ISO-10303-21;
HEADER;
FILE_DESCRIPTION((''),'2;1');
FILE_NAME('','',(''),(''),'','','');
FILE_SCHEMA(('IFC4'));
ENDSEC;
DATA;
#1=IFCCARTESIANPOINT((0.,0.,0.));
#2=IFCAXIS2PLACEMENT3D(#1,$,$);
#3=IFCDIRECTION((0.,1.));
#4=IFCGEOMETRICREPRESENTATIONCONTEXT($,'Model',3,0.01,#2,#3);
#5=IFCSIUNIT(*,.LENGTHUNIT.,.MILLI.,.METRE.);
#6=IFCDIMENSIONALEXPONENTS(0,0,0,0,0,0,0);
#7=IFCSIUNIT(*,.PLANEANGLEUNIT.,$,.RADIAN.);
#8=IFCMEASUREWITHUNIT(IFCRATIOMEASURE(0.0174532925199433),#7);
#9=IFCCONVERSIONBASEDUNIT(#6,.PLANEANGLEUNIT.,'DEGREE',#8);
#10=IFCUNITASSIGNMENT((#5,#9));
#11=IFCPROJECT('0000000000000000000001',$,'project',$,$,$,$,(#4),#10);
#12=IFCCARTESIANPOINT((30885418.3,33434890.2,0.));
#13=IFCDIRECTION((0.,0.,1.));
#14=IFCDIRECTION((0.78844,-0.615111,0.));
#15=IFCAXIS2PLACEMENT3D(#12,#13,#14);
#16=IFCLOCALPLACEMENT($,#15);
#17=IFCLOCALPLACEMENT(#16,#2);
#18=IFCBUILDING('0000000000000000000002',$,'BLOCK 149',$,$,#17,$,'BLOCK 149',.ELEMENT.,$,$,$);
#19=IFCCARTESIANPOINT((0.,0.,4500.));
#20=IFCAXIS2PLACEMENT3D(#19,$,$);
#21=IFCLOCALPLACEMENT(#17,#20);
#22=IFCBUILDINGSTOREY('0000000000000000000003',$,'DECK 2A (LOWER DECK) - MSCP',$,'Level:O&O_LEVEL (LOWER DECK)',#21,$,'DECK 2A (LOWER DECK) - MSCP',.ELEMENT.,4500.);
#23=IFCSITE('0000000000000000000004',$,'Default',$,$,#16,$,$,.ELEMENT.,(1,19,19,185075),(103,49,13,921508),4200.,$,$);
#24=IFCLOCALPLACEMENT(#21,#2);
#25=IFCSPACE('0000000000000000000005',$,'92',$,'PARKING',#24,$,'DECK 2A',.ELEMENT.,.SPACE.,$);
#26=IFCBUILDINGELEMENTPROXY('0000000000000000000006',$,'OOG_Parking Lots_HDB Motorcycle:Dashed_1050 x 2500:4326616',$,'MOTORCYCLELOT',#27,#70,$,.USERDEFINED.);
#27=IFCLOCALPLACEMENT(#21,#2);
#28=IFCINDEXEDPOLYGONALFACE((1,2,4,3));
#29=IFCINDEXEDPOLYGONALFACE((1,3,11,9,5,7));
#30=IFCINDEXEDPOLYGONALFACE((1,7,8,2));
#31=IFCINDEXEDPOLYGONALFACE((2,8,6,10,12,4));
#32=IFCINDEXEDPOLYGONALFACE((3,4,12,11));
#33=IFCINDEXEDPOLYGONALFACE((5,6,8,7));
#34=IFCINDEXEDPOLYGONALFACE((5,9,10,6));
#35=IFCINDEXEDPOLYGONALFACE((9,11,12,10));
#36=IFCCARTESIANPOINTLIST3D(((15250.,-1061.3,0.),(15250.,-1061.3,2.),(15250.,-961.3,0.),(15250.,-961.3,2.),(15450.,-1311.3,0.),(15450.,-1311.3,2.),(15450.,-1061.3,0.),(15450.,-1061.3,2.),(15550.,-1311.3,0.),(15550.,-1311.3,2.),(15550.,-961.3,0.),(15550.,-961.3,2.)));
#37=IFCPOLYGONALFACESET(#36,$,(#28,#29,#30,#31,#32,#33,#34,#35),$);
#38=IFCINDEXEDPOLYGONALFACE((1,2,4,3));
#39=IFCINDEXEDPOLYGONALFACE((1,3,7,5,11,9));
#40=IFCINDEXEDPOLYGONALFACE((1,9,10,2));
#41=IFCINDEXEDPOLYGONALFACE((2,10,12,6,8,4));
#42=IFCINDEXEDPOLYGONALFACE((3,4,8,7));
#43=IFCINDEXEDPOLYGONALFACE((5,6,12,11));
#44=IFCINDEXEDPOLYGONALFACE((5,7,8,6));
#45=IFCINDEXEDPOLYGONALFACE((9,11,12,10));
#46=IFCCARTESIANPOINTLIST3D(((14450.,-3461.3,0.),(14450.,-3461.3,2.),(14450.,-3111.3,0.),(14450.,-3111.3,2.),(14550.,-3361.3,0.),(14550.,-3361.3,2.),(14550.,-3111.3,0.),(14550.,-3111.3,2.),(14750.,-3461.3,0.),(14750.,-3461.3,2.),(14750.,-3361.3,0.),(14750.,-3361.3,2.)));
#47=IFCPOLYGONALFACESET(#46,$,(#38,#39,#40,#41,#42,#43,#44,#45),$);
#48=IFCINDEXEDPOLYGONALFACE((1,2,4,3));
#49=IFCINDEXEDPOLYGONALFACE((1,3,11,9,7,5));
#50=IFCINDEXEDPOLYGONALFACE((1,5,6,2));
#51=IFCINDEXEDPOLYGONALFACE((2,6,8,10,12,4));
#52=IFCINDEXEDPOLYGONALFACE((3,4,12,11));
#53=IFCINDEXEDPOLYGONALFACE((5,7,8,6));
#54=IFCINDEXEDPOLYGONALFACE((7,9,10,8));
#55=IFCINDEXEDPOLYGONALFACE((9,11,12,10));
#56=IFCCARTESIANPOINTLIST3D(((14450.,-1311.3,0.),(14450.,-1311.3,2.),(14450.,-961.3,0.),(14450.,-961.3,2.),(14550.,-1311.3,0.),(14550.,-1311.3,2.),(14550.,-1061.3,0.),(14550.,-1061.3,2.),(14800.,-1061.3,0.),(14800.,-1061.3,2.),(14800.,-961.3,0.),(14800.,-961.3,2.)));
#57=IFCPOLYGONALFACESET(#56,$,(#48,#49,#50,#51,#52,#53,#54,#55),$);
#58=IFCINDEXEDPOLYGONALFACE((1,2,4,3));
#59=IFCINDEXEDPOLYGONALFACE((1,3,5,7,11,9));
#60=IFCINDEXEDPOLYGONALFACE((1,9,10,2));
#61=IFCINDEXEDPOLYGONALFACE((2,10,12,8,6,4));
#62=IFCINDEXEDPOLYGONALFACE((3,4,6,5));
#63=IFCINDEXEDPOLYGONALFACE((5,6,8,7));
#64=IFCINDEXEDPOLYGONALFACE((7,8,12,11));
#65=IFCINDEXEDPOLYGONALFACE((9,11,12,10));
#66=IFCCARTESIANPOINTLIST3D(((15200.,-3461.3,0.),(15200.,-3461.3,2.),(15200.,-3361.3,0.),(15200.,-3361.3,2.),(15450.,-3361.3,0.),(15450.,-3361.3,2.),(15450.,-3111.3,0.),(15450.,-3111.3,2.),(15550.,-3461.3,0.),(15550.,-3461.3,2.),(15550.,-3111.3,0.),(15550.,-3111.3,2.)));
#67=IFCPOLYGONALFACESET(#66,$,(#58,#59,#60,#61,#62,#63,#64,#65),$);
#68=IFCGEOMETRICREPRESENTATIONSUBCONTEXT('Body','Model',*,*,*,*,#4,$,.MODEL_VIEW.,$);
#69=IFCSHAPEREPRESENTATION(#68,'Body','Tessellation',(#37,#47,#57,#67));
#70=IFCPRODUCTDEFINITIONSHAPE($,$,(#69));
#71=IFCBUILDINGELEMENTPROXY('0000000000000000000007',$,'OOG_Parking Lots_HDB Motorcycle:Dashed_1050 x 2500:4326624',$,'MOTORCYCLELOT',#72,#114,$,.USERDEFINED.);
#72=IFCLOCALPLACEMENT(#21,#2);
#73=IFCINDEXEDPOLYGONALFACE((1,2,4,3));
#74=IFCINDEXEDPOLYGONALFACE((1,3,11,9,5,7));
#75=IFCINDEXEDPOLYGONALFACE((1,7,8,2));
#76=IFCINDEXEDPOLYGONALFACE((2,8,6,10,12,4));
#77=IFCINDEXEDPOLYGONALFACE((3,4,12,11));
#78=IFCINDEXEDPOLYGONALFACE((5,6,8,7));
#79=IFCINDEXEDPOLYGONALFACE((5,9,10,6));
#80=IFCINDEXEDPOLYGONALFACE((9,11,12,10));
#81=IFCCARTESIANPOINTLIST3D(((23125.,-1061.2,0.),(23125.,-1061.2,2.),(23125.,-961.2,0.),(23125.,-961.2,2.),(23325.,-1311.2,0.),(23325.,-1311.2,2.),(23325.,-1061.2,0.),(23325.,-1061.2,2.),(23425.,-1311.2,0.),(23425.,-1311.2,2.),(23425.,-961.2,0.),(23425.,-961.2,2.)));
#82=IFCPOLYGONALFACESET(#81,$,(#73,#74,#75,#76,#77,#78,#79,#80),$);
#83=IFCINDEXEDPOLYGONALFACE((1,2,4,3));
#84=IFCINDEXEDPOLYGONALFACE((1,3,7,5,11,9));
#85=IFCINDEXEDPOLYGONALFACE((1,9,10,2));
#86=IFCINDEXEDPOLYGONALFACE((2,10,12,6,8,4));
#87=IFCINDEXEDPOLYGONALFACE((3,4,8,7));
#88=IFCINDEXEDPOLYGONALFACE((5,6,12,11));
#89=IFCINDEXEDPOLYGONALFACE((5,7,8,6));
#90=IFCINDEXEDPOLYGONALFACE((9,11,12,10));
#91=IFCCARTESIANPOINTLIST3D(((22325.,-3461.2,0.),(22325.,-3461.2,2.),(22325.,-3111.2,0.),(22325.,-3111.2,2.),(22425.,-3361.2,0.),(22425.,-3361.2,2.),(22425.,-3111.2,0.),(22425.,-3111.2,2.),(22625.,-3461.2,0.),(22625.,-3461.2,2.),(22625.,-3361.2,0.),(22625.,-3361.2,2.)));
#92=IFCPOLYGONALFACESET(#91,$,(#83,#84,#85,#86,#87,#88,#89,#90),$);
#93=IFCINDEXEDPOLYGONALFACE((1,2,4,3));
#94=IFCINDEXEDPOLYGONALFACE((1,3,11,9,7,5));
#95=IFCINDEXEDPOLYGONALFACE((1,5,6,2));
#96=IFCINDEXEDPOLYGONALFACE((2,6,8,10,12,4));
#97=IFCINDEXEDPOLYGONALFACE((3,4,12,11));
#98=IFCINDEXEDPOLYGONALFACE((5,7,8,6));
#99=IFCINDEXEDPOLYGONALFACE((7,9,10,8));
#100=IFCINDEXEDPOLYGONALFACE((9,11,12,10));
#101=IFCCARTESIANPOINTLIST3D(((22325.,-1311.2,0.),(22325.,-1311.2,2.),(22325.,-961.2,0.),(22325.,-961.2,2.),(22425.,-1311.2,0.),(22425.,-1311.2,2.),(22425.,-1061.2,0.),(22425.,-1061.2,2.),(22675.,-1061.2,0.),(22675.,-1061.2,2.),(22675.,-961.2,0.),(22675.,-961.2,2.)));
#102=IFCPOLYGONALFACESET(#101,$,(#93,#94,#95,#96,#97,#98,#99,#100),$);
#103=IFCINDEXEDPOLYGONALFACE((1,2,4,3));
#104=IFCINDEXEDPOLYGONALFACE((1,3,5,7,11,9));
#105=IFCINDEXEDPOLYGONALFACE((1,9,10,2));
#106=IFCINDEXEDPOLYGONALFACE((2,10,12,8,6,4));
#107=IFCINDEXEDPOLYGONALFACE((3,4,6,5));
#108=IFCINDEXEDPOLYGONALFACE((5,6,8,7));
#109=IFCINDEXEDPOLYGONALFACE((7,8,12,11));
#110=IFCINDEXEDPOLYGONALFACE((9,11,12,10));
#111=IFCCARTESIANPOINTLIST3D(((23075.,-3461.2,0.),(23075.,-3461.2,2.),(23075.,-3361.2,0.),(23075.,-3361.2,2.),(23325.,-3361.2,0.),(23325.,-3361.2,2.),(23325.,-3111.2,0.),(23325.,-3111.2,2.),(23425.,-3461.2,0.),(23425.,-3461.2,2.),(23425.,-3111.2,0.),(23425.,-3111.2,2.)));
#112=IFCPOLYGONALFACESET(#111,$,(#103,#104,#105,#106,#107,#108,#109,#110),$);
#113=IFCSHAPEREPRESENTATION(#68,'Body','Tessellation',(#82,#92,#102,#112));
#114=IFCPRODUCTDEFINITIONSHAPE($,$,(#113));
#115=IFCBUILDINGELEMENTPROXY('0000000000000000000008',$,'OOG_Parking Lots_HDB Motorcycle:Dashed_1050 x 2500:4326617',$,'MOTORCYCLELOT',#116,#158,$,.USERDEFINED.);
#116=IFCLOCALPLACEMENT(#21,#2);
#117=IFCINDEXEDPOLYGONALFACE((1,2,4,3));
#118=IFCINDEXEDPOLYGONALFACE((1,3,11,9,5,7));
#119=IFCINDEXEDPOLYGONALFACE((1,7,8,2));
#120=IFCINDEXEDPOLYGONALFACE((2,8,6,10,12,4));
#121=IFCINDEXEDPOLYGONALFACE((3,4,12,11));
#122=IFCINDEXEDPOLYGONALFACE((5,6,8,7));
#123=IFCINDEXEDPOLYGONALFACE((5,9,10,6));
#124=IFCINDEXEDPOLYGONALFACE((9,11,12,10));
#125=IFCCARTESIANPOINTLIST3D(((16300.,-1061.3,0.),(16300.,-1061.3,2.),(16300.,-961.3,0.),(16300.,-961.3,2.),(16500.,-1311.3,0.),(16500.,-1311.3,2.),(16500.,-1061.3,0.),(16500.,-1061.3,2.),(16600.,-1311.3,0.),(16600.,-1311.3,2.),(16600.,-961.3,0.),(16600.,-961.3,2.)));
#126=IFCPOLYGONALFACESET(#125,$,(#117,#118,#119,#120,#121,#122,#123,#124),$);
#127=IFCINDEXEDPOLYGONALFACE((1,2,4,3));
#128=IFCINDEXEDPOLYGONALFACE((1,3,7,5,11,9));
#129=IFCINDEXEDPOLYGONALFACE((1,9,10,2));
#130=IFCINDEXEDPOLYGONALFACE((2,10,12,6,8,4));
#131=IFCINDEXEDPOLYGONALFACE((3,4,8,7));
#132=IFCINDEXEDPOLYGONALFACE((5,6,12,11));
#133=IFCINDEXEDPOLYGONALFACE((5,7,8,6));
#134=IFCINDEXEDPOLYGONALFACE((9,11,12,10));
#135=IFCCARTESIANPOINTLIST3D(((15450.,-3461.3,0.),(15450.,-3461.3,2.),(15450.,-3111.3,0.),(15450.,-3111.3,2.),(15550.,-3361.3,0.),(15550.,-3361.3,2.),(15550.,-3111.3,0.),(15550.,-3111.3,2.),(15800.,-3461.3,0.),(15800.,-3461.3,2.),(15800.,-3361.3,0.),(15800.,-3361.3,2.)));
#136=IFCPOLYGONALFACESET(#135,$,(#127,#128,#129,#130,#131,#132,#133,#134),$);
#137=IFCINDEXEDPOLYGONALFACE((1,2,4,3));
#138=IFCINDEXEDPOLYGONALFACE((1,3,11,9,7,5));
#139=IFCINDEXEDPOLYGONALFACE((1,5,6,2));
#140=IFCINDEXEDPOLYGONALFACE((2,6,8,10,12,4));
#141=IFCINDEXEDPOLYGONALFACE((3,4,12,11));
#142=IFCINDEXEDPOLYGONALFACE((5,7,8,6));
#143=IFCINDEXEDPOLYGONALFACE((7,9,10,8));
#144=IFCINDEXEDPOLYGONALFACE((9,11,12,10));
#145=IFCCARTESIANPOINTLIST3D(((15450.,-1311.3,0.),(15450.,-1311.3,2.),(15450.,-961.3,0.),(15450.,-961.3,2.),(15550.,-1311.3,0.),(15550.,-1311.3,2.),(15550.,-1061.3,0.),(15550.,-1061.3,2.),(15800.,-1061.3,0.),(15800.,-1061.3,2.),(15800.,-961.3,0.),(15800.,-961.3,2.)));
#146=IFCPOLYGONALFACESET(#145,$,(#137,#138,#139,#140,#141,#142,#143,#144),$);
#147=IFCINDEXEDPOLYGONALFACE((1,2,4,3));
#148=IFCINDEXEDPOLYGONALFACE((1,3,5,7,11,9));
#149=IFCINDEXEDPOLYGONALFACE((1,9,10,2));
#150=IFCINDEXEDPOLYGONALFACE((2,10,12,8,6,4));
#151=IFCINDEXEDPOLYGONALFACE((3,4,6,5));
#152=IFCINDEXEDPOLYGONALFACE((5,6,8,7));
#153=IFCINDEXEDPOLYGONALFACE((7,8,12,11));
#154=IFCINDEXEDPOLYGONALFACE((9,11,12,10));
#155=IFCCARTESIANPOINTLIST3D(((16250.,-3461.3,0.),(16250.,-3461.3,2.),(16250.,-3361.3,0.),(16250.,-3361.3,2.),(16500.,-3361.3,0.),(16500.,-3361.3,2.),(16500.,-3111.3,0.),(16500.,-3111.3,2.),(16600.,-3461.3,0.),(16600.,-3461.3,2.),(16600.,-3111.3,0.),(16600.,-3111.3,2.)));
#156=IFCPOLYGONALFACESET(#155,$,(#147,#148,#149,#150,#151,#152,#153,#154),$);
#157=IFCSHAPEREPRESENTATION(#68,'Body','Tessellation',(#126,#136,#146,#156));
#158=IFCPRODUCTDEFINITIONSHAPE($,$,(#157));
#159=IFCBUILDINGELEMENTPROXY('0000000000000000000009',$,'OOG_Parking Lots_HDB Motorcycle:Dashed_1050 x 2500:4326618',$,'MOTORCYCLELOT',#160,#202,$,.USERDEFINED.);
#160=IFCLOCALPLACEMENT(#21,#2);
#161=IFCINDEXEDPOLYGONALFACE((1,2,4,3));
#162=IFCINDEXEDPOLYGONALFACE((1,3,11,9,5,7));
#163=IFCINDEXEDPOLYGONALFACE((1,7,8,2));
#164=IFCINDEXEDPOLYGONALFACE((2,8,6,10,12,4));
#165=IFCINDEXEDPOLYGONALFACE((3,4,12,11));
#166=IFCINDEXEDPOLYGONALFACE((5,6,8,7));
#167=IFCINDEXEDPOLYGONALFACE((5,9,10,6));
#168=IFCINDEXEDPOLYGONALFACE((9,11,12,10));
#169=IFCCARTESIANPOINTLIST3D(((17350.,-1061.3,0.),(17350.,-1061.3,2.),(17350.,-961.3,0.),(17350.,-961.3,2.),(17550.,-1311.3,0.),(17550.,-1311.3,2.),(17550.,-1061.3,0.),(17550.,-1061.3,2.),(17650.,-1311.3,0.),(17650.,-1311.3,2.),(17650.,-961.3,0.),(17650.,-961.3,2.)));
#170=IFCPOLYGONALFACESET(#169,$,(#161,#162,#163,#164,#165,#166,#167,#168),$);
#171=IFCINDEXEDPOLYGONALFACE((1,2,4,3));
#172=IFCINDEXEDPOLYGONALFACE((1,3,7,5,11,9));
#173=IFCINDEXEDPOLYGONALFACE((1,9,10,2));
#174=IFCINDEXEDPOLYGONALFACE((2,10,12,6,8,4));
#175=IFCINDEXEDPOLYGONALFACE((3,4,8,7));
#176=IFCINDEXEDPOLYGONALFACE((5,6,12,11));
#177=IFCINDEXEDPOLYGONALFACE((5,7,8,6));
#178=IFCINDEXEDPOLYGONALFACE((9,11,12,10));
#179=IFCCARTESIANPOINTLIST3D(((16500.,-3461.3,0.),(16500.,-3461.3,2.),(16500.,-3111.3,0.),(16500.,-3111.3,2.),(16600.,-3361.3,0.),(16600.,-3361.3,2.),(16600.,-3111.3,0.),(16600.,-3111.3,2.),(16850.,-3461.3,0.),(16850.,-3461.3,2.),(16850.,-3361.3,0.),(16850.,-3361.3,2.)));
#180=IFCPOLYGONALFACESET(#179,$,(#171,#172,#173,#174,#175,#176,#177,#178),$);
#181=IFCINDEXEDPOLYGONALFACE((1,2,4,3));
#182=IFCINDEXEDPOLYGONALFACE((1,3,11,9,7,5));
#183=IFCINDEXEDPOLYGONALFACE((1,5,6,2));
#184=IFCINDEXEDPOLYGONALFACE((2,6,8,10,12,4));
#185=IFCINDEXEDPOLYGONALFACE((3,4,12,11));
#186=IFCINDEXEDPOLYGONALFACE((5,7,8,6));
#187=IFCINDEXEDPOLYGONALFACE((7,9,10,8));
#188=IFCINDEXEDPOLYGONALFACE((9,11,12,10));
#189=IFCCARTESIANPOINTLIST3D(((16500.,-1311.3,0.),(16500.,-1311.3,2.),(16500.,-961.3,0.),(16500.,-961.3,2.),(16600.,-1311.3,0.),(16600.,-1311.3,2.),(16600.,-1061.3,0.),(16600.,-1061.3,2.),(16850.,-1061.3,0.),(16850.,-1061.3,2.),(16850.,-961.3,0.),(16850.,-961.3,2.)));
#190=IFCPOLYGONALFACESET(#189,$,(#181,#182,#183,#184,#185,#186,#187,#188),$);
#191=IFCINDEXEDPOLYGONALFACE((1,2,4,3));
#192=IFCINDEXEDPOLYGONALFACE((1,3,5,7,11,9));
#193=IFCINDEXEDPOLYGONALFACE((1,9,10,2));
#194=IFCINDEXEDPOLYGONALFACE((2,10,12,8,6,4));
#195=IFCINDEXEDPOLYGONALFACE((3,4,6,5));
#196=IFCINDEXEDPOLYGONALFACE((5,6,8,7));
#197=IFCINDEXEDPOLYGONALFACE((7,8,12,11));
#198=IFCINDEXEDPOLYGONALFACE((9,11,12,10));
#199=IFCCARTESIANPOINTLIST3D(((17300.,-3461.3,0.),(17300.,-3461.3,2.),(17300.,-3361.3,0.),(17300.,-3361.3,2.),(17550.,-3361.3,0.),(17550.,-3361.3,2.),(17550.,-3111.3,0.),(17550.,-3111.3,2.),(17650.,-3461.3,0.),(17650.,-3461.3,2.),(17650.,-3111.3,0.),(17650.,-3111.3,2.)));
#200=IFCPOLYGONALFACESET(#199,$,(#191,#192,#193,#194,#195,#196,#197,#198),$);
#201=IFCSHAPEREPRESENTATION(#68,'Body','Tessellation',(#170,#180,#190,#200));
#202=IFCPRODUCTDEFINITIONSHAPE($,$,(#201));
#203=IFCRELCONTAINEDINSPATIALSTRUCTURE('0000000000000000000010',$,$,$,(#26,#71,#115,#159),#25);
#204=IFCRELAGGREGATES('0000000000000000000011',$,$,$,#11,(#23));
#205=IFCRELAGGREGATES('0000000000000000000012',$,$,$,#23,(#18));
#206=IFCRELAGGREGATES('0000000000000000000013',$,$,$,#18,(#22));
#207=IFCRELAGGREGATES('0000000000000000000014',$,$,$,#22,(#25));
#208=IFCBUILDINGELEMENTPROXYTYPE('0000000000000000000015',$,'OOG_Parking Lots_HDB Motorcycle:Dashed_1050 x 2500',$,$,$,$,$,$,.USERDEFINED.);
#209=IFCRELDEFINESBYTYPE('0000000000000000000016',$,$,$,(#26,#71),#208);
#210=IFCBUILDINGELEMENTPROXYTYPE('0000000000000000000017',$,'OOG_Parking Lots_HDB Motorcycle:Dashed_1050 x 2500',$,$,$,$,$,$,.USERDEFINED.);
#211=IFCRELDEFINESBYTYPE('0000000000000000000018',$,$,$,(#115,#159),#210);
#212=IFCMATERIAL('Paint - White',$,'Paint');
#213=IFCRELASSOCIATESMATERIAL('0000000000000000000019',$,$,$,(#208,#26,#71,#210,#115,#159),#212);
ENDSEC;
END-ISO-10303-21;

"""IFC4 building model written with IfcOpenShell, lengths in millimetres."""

from ifc_helpers import new_model, entity, si_unit, converted_unit, direction, frame, origin, place, context, subcontext, project, spatial, indexed_curve, outline, extrude, source, transform, mapped, material, type_object, type_shapes, element, save


model = new_model("IFC4")

# Units and contexts
model_context = context("Model", 3, precision=0.01, world=origin(), true_north=direction((0.0, 1.0)))
body_context = subcontext(model_context, "Body", "Model", "MODEL_VIEW")
ifc_project = project(units=[si_unit("LENGTHUNIT", "METRE", prefix="MILLI"), converted_unit("PLANEANGLEUNIT", "DEGREE", entity("IfcRatioMeasure", 0.0174532925199433), si_unit("PLANEANGLEUNIT", "RADIAN"), dimensions=[0, 0, 0, 0, 0, 0, 0])], contexts=[model_context])

# Site, building, storey
site_placement = place(None, frame((30885418.3, 33434890.2, 0.0), z_axis=(0.0, 0.0, 1.0), x_axis=(0.78844, -0.615111, 0.0)))
site = spatial("IfcSite", under=ifc_project, at=site_placement, Name="Default", CompositionType="ELEMENT", RefLatitude=(1, 19, 19, 185075), RefLongitude=(103, 49, 13, 921508), RefElevation=4200.0)
building_placement = place(site_placement, origin())
building = spatial("IfcBuilding", under=site, at=building_placement, Name="BLOCK 149", LongName="BLOCK 149", CompositionType="ELEMENT")
storey_placement = place(building_placement, frame((0.0, 0.0, 4500.0)))
storey = spatial("IfcBuildingStorey", under=building, at=storey_placement, Name="DECK 2A (LOWER DECK) - MSCP", ObjectType="Level:O&O_LEVEL (LOWER DECK)", LongName="DECK 2A (LOWER DECK) - MSCP", CompositionType="ELEMENT", Elevation=4500.0)

# Shared definitions
space_placement = place(storey_placement, origin())
space = spatial("IfcSpace", under=storey, at=space_placement, Name="92", ObjectType="PARKING", LongName="DECK 2A", CompositionType="ELEMENT", PredefinedType="SPACE")

# Building element proxies
ifc_material_1 = material(Name="Paint - White", Category="Paint")
building_element_proxy_type_1 = type_object("IfcBuildingElementProxyType", Name="OOG_Parking Lots_HDB Motorcycle:Dashed_1050 x 2500", PredefinedType="USERDEFINED", material=ifc_material_1)
shared_shape_1 = source(origin(), body_context, "Body", "SweptSolid", [
    extrude(outline(indexed_curve([(-200.0, -133.3), (150.0, -133.3), (150.0, 166.7), (50.0, 166.7), (50.0, -33.3), (-200.0, -33.3), (-200.0, -133.3)], self_intersect=False)), frame((916.7, -100.0, 0.0), z_axis=(0.0, 0.0, 1.0), x_axis=(0.0, 1.0, 0.0)), (0.0, 0.0, 1.0), 2.0),
    extrude(outline(indexed_curve([(-200.0, -133.3), (150.0, -133.3), (150.0, 166.7), (50.0, 166.7), (50.0, -33.3), (-200.0, -33.3), (-200.0, -133.3)], self_intersect=False)), frame((83.3, -2300.0, 0.0), z_axis=(0.0, 0.0, 1.0), x_axis=(0.0, -1.0, 0.0)), (0.0, 0.0, 1.0), 2.0),
    extrude(outline(indexed_curve([(-200.0, -150.0), (150.0, -150.0), (150.0, 200.0), (50.0, 200.0), (50.0, -50.0), (-200.0, -50.0), (-200.0, -150.0)], self_intersect=False)), frame((100.0, -100.0, 0.0), z_axis=(0.0, 0.0, 1.0), x_axis=(-1.0, 0.0, 0.0)), (0.0, 0.0, 1.0), 2.0),
    extrude(outline(indexed_curve([(-200.0, -150.0), (150.0, -150.0), (150.0, 200.0), (50.0, 200.0), (50.0, -50.0), (-200.0, -50.0), (-200.0, -150.0)], self_intersect=False)), frame((900.0, -2300.0, 0.0)), (0.0, 0.0, 1.0), 2.0),
])
type_shapes(building_element_proxy_type_1, [shared_shape_1])
for number, where, name in (
    (1, (14500.0, -1011.3, 0.0), "OOG_Parking Lots_HDB Motorcycle:Dashed_1050 x 2500:4326616"),
    (2, (22375.0, -1011.2, 0.0), "OOG_Parking Lots_HDB Motorcycle:Dashed_1050 x 2500:4326624"),
):
    element("IfcBuildingElementProxy", number, at=place(space_placement, frame(where)), inside=space, type_object=building_element_proxy_type_1, material=ifc_material_1, Name=name, ObjectType="MOTORCYCLELOT", PredefinedType="USERDEFINED", context=body_context, shape_type="MappedRepresentation", body=[
        mapped(shared_shape_1, transform((0.0, 0.0, 0.0), scale=1.0)),
    ])
building_element_proxy_type_2 = type_object("IfcBuildingElementProxyType", Name="OOG_Parking Lots_HDB Motorcycle:Dashed_1050 x 2500", PredefinedType="USERDEFINED", material=ifc_material_1)
shared_shape_2 = source(origin(), body_context, "Body", "SweptSolid", [
    extrude(outline(indexed_curve([(-200.0, -133.3), (150.0, -133.3), (150.0, 166.7), (50.0, 166.7), (50.0, -33.3), (-200.0, -33.3), (-200.0, -133.3)], self_intersect=False)), frame((966.7, -100.0, 0.0), z_axis=(0.0, 0.0, 1.0), x_axis=(0.0, 1.0, 0.0)), (0.0, 0.0, 1.0), 2.0),
    extrude(outline(indexed_curve([(-200.0, -150.0), (150.0, -150.0), (150.0, 200.0), (50.0, 200.0), (50.0, -50.0), (-200.0, -50.0), (-200.0, -150.0)], self_intersect=False)), frame((100.0, -2300.0, 0.0), z_axis=(0.0, 0.0, 1.0), x_axis=(0.0, -1.0, 0.0)), (0.0, 0.0, 1.0), 2.0),
    extrude(outline(indexed_curve([(-200.0, -150.0), (150.0, -150.0), (150.0, 200.0), (50.0, 200.0), (50.0, -50.0), (-200.0, -50.0), (-200.0, -150.0)], self_intersect=False)), frame((100.0, -100.0, 0.0), z_axis=(0.0, 0.0, 1.0), x_axis=(-1.0, 0.0, 0.0)), (0.0, 0.0, 1.0), 2.0),
    extrude(outline(indexed_curve([(-200.0, -150.0), (150.0, -150.0), (150.0, 200.0), (50.0, 200.0), (50.0, -50.0), (-200.0, -50.0), (-200.0, -150.0)], self_intersect=False)), frame((950.0, -2300.0, 0.0)), (0.0, 0.0, 1.0), 2.0),
])
type_shapes(building_element_proxy_type_2, [shared_shape_2])
for number, where, name in (
    (3, (15500.0, -1011.3, 0.0), "OOG_Parking Lots_HDB Motorcycle:Dashed_1050 x 2500:4326617"),
    (4, (16550.0, -1011.3, 0.0), "OOG_Parking Lots_HDB Motorcycle:Dashed_1050 x 2500:4326618"),
):
    element("IfcBuildingElementProxy", number, at=place(space_placement, frame(where)), inside=space, type_object=building_element_proxy_type_2, material=ifc_material_1, Name=name, ObjectType="MOTORCYCLELOT", PredefinedType="USERDEFINED", context=body_context, shape_type="MappedRepresentation", body=[
        mapped(shared_shape_2, transform((0.0, 0.0, 0.0), scale=1.0)),
    ])

save(model, "model.ifc")
